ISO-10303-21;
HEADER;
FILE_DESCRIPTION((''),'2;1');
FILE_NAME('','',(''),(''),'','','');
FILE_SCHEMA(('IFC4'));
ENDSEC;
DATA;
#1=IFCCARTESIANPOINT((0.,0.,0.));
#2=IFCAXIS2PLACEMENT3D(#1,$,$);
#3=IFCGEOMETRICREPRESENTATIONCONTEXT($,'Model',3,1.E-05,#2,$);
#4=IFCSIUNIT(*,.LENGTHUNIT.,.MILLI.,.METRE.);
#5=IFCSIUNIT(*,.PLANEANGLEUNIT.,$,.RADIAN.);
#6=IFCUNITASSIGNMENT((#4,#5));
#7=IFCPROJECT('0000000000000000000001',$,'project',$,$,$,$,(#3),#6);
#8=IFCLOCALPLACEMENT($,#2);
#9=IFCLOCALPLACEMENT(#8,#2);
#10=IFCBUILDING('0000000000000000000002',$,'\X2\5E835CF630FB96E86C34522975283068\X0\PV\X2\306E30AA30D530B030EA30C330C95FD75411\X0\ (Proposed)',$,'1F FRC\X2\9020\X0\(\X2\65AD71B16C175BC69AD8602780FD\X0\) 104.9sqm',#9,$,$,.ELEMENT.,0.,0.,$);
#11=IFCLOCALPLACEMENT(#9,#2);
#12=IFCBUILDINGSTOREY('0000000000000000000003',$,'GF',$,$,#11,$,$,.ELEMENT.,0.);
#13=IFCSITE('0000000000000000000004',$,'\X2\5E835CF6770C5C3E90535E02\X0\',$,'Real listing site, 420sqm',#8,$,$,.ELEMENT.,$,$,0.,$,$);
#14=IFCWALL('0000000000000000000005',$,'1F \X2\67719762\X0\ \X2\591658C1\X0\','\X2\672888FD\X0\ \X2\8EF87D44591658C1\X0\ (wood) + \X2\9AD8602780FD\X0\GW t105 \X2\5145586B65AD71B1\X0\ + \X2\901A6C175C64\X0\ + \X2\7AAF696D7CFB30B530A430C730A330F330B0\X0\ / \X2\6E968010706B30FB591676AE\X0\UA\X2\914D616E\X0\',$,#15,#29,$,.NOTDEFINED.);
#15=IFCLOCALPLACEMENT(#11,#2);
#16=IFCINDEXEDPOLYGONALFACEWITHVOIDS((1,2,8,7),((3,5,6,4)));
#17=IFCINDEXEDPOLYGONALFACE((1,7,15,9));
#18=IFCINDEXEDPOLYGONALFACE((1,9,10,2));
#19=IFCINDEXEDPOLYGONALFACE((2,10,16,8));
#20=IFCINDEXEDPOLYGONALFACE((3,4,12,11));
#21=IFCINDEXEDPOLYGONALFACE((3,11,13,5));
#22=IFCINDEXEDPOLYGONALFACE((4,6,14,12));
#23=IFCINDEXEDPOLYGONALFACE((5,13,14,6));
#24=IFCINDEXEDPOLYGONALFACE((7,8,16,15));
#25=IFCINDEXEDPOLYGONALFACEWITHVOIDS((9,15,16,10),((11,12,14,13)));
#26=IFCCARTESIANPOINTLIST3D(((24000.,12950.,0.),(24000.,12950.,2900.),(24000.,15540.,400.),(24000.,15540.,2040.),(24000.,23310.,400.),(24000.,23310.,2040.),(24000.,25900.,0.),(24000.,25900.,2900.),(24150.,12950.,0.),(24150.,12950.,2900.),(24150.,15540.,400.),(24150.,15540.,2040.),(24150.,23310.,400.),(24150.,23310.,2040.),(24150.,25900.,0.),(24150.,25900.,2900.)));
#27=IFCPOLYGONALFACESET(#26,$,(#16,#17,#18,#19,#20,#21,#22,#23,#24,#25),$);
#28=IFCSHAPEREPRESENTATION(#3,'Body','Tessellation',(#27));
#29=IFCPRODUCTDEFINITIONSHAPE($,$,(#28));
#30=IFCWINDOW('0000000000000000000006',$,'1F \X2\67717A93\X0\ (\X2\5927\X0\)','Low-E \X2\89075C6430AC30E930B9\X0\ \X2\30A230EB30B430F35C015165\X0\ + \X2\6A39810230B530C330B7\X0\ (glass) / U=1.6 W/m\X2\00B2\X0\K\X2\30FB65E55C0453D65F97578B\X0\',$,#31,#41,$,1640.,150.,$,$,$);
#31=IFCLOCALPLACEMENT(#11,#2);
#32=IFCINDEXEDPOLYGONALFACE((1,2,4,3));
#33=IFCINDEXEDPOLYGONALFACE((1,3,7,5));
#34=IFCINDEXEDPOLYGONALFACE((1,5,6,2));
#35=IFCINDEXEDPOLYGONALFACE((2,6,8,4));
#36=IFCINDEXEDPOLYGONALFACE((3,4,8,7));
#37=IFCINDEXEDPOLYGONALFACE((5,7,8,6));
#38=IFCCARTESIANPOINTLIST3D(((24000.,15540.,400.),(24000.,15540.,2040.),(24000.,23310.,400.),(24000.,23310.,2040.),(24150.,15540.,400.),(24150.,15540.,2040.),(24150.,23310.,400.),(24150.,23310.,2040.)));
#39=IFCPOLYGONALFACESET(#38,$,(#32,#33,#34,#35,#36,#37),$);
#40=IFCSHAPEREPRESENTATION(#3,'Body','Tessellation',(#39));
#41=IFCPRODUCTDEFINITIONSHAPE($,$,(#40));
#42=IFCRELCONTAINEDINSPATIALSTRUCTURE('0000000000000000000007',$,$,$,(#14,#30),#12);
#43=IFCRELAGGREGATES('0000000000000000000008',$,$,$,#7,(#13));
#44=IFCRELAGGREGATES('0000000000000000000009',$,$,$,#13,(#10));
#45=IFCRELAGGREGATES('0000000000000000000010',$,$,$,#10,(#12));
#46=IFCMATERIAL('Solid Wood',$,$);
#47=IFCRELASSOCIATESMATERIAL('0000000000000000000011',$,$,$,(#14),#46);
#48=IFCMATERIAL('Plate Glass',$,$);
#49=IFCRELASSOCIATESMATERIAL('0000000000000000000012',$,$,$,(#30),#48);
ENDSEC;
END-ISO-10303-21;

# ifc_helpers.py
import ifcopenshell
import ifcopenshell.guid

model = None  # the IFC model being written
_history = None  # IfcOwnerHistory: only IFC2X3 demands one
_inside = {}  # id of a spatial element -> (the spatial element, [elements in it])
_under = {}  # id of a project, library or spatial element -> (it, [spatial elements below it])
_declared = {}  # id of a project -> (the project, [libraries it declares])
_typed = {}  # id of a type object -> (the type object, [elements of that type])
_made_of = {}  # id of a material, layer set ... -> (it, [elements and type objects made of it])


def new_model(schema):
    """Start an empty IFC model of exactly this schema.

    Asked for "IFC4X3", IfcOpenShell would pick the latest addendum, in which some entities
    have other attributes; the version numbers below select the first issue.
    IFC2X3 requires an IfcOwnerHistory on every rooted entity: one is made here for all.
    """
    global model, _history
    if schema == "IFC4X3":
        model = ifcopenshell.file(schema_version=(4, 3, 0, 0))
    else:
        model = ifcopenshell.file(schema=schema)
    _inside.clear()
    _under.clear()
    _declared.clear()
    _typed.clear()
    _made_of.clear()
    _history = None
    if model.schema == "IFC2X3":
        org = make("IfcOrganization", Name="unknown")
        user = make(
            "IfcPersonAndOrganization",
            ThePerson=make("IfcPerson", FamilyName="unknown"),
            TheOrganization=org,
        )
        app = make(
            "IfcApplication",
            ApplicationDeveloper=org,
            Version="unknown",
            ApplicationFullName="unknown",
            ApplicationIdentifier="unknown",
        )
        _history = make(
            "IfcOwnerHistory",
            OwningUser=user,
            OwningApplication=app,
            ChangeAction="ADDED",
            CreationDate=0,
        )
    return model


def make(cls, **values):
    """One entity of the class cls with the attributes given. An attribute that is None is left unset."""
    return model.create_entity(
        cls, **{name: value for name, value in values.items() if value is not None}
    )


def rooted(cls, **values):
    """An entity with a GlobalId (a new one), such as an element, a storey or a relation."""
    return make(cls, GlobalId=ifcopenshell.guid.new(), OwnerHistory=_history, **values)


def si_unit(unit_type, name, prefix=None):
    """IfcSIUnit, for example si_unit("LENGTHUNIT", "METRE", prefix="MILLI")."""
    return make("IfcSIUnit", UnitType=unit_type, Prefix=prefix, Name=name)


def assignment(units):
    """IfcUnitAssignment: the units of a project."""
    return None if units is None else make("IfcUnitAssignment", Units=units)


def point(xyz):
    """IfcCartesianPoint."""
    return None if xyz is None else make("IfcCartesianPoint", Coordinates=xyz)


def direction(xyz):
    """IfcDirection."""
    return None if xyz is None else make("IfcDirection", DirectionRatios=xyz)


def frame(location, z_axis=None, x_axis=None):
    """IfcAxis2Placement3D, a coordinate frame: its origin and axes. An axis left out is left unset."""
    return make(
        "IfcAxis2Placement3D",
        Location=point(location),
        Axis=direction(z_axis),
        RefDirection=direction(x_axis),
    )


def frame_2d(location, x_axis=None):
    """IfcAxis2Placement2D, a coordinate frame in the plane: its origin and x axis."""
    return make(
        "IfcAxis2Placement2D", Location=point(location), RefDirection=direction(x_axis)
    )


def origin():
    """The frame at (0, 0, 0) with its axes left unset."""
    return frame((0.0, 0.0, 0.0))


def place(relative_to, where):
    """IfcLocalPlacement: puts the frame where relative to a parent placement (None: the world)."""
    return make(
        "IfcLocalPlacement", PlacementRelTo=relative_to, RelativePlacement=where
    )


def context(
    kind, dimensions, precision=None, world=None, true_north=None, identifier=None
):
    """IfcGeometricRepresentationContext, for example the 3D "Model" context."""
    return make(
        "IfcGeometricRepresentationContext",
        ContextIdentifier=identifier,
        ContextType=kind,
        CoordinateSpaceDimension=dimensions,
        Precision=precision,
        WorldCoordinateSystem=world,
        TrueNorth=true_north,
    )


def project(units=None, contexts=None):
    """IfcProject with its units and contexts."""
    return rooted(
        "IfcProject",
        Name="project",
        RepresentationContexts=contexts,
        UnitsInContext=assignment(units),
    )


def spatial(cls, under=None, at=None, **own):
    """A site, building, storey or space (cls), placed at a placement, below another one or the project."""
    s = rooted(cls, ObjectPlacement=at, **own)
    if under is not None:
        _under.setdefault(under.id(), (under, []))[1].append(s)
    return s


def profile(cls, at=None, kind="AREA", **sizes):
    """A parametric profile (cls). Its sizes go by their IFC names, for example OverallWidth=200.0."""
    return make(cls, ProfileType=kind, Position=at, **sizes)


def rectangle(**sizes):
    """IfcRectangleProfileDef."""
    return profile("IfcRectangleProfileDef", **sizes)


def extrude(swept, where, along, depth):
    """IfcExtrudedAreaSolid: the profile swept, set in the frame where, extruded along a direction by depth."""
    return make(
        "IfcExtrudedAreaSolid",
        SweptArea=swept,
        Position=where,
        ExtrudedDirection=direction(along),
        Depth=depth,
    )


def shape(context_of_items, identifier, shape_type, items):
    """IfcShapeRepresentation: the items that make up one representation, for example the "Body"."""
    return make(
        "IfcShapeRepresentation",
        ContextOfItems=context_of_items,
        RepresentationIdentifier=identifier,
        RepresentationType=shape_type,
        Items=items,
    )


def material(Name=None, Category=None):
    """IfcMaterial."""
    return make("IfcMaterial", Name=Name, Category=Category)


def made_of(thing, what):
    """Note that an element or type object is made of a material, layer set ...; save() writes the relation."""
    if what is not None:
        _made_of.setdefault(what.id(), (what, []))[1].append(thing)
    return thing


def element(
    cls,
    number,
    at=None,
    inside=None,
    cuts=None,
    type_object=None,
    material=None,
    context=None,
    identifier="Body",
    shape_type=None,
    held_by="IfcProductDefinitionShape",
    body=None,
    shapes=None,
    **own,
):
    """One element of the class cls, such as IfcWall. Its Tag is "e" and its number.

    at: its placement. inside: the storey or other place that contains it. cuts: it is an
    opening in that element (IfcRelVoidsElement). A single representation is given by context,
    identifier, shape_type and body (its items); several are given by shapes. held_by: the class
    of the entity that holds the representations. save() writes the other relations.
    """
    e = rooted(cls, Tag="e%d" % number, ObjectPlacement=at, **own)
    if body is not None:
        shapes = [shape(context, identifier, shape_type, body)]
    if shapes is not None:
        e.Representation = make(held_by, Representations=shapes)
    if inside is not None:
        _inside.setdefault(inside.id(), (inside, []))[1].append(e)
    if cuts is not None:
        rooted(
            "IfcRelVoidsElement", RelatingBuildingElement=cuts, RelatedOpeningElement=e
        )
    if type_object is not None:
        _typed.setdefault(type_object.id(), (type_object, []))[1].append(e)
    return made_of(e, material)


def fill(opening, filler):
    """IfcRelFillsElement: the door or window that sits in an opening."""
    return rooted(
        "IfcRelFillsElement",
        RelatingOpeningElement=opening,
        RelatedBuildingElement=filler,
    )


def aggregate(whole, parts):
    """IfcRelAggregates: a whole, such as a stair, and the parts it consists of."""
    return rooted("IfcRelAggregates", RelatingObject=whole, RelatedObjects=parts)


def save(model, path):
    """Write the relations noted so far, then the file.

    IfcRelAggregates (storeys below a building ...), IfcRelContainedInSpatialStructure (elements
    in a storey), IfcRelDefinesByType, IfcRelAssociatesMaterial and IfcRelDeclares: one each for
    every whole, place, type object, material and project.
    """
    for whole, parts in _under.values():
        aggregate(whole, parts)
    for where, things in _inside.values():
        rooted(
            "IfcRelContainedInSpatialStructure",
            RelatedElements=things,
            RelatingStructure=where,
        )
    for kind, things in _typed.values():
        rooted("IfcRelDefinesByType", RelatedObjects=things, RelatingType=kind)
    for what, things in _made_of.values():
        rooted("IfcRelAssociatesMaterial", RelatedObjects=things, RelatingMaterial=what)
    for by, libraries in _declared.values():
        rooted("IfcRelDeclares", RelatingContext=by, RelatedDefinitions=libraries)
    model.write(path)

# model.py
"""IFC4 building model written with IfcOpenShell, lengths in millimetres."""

from ifc_helpers import new_model, si_unit, frame, frame_2d, origin, place, context, project, spatial, rectangle, extrude, material, element, fill, save


model = new_model("IFC4")

# Units and contexts
model_context = context("Model", 3, precision=1e-05, world=origin())
ifc_project = project(units=[si_unit("LENGTHUNIT", "METRE", prefix="MILLI"), si_unit("PLANEANGLEUNIT", "RADIAN")], contexts=[model_context])

# Site, building, storey
site_placement = place(None, origin())
site = spatial("IfcSite", under=ifc_project, at=site_placement, Name="広島県尾道市", ObjectType="Real listing site, 420sqm", CompositionType="ELEMENT", RefElevation=0.0)
building_placement = place(site_placement, origin())
building = spatial("IfcBuilding", under=site, at=building_placement, Name="広島・雨水利用とPVのオフグリッド志向 (Proposed)", ObjectType="1F FRC造(断熱気密高性能) 104.9sqm", CompositionType="ELEMENT", ElevationOfRefHeight=0.0, ElevationOfTerrain=0.0)
storey_placement = place(building_placement, origin())
storey = spatial("IfcBuildingStorey", under=building, at=storey_placement, Name="GF", CompositionType="ELEMENT", Elevation=0.0)

# Shared definitions
ifc_material_1 = material(Name="Solid Wood")

# Wall, opening, window
wall_1_placement = place(storey_placement, frame((12000.0, 6475.0, 0.0)))
wall_1 = element("IfcWall", 1, at=wall_1_placement, inside=storey, material=ifc_material_1, Name="1F 東面 外壁", Description="木製 軸組外壁 (wood) + 高性能GW t105 充填断熱 + 通気層 + 窯業系サイディング / 準耐火・外皮UA配慮", PredefinedType="NOTDEFINED", context=model_context, shape_type="SweptSolid", body=[
    extrude(rectangle(XDim=150.0, YDim=12950.0, at=frame_2d((75.0, 6475.0))), frame((12000.0, 6475.0, 0.0)), (0.0, 0.0, 1.0), 2900.0),
])
opening_placement = place(storey_placement, frame((12000.0, 7770.0, 200.0)))
opening = element("IfcOpeningElement", 2, at=opening_placement, cuts=wall_1, PredefinedType="NOTDEFINED", context=model_context, shape_type="SweptSolid", body=[
    extrude(rectangle(XDim=150.0, YDim=7770.0, at=frame_2d((75.0, 3885.0))), frame((12000.0, 7770.0, 200.0)), (0.0, 0.0, 1.0), 1640.0),
])
ifc_material_2 = material(Name="Plate Glass")
window_placement = place(storey_placement, frame((12000.0, 7770.0, 200.0)))
window = element("IfcWindow", 3, at=window_placement, inside=storey, material=ifc_material_2, Name="1F 東窓 (大)", Description="Low-E 複層ガラス アルゴン封入 + 樹脂サッシ (glass) / U=1.6 W/m²K・日射取得型", OverallHeight=1640.0, OverallWidth=150.0, context=model_context, shape_type="SweptSolid", body=[
    extrude(rectangle(XDim=150.0, YDim=7770.0, at=frame_2d((75.0, 3885.0))), frame((12000.0, 7770.0, 200.0)), (0.0, 0.0, 1.0), 1640.0),
])
fill(opening, window)

save(model, "model.ifc")
